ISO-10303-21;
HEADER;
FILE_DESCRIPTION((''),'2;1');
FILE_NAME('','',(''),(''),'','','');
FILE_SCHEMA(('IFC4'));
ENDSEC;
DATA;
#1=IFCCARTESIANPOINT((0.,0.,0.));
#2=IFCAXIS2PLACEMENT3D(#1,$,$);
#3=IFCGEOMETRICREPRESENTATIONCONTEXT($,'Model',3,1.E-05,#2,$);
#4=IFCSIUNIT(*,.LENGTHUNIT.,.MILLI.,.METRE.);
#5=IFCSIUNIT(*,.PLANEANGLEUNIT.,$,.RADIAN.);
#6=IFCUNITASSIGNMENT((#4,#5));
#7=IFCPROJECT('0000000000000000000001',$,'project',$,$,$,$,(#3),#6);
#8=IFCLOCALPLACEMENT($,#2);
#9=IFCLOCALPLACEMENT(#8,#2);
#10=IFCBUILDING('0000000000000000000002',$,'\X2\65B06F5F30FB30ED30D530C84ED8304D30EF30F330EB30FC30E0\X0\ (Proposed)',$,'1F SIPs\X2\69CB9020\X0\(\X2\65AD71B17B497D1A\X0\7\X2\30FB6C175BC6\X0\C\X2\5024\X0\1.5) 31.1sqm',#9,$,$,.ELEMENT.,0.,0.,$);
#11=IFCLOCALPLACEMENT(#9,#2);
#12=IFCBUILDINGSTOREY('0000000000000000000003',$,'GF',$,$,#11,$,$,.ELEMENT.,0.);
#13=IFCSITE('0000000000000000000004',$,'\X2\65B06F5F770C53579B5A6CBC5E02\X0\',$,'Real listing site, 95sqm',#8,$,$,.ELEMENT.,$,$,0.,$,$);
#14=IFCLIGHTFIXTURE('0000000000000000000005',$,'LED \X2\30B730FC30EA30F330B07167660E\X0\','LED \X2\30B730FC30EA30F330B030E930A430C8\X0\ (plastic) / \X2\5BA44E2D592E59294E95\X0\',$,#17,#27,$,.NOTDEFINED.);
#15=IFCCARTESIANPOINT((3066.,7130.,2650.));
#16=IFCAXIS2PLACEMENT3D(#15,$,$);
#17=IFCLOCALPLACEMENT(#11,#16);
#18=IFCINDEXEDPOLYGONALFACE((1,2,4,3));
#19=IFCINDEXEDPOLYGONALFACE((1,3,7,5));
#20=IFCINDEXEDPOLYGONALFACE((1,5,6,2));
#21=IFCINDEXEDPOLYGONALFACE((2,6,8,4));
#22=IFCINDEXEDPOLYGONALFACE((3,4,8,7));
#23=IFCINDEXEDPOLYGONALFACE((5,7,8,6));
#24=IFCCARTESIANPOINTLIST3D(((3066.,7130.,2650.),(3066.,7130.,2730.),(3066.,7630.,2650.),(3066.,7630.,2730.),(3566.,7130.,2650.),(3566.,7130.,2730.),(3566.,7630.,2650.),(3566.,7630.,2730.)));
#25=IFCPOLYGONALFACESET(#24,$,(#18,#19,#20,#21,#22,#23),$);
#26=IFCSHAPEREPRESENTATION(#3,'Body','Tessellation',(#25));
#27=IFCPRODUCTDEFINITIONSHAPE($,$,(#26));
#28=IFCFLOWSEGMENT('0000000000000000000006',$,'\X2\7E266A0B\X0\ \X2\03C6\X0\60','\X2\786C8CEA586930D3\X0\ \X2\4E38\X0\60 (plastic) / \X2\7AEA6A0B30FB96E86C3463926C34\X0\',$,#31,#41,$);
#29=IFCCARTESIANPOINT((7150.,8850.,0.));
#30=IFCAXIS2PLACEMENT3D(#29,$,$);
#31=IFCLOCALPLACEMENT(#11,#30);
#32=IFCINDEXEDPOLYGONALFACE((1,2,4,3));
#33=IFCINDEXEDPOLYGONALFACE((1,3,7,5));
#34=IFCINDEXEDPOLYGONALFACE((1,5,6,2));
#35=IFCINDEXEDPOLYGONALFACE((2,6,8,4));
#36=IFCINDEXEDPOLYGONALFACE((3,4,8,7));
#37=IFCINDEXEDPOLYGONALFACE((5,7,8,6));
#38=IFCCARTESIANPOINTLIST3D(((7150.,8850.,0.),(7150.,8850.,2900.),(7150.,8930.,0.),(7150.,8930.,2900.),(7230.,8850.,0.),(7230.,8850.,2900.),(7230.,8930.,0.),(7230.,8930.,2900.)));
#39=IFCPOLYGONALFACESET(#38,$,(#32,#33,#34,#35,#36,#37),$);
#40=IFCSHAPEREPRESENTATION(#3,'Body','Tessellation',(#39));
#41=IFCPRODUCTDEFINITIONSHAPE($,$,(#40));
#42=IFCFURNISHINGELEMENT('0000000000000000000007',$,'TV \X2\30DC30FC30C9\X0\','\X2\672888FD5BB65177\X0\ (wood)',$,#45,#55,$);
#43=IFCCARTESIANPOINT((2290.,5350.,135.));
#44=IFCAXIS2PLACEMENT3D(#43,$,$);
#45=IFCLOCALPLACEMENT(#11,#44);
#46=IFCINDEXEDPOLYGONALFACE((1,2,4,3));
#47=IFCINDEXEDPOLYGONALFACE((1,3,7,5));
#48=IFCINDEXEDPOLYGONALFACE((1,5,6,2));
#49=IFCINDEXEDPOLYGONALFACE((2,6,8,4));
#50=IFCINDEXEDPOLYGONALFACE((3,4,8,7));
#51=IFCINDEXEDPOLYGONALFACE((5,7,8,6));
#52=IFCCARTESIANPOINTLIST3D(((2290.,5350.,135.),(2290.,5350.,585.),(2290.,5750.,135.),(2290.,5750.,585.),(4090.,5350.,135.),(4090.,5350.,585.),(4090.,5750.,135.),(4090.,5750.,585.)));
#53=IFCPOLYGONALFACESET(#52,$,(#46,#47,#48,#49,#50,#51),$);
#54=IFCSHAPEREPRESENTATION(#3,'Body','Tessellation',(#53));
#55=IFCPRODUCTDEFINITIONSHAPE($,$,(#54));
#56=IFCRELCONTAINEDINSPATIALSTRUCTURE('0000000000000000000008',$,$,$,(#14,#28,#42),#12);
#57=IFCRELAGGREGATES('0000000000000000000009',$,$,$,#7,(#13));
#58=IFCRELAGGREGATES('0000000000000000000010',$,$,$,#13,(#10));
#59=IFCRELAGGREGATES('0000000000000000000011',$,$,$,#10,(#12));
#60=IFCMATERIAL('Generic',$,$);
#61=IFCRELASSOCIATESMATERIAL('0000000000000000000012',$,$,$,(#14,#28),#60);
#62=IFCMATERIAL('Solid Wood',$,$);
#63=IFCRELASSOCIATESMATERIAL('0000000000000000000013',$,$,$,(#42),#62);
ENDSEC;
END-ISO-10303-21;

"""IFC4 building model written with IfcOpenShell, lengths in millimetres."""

from ifc_helpers import new_model, si_unit, frame, frame_2d, origin, place, context, project, spatial, rectangle, extrude, material, element, save


model = new_model("IFC4")

# Units and contexts
model_context = context("Model", 3, precision=1e-05, world=origin())
ifc_project = project(units=[si_unit("LENGTHUNIT", "METRE", prefix="MILLI"), si_unit("PLANEANGLEUNIT", "RADIAN")], contexts=[model_context])

# Site, building, storey
site_placement = place(None, origin())
site = spatial("IfcSite", under=ifc_project, at=site_placement, Name="新潟県南魚沼市", ObjectType="Real listing site, 95sqm", CompositionType="ELEMENT", RefElevation=0.0)
building_placement = place(site_placement, origin())
building = spatial("IfcBuilding", under=site, at=building_placement, Name="新潟・ロフト付きワンルーム (Proposed)", ObjectType="1F SIPs構造(断熱等級7・気密C値1.5) 31.1sqm", CompositionType="ELEMENT", ElevationOfRefHeight=0.0, ElevationOfTerrain=0.0)
storey_placement = place(building_placement, origin())
storey = spatial("IfcBuildingStorey", under=building, at=storey_placement, Name="GF", CompositionType="ELEMENT", Elevation=0.0)

# Shared definitions
ifc_material_1 = material(Name="Solid Wood")

# Shared definitions
ifc_material_2 = material(Name="Generic")

# Light fixture
light_fixture_1_placement = place(storey_placement, frame((3066.0, 7130.0, 2650.0)))
element("IfcLightFixture", 1, at=light_fixture_1_placement, inside=storey, material=ifc_material_2, Name="LED シーリング照明", Description="LED シーリングライト (plastic) / 室中央天井", PredefinedType="NOTDEFINED", context=model_context, shape_type="SweptSolid", body=[
    extrude(rectangle(XDim=500.0, YDim=500.0, at=frame_2d((250.0, 250.0))), frame((3066.0, 7130.0, 2650.0)), (0.0, 0.0, 1.0), 80.0),
])

# Flow segment
flow_segment_placement = place(storey_placement, frame((7150.0, 8850.0, 0.0)))
element("IfcFlowSegment", 2, at=flow_segment_placement, inside=storey, material=ifc_material_2, Name="縦樋 φ60", Description="硬質塩ビ 丸60 (plastic) / 竪樋・雨水排水", context=model_context, shape_type="SweptSolid", body=[
    extrude(rectangle(XDim=80.0, YDim=80.0, at=frame_2d((40.0, 40.0))), frame((7150.0, 8850.0, 0.0)), (0.0, 0.0, 1.0), 2900.0),
])

# Furnishing element
furnishing_placement = place(storey_placement, frame((2290.0, 5350.0, 135.0)))
element("IfcFurnishingElement", 3, at=furnishing_placement, inside=storey, material=ifc_material_1, Name="TV ボード", Description="木製家具 (wood)", context=model_context, shape_type="SweptSolid", body=[
    extrude(rectangle(XDim=1800.0, YDim=400.0, at=frame_2d((900.0, 200.0))), frame((2290.0, 5350.0, 135.0)), (0.0, 0.0, 1.0), 450.0),
])

save(model, "model.ifc")
